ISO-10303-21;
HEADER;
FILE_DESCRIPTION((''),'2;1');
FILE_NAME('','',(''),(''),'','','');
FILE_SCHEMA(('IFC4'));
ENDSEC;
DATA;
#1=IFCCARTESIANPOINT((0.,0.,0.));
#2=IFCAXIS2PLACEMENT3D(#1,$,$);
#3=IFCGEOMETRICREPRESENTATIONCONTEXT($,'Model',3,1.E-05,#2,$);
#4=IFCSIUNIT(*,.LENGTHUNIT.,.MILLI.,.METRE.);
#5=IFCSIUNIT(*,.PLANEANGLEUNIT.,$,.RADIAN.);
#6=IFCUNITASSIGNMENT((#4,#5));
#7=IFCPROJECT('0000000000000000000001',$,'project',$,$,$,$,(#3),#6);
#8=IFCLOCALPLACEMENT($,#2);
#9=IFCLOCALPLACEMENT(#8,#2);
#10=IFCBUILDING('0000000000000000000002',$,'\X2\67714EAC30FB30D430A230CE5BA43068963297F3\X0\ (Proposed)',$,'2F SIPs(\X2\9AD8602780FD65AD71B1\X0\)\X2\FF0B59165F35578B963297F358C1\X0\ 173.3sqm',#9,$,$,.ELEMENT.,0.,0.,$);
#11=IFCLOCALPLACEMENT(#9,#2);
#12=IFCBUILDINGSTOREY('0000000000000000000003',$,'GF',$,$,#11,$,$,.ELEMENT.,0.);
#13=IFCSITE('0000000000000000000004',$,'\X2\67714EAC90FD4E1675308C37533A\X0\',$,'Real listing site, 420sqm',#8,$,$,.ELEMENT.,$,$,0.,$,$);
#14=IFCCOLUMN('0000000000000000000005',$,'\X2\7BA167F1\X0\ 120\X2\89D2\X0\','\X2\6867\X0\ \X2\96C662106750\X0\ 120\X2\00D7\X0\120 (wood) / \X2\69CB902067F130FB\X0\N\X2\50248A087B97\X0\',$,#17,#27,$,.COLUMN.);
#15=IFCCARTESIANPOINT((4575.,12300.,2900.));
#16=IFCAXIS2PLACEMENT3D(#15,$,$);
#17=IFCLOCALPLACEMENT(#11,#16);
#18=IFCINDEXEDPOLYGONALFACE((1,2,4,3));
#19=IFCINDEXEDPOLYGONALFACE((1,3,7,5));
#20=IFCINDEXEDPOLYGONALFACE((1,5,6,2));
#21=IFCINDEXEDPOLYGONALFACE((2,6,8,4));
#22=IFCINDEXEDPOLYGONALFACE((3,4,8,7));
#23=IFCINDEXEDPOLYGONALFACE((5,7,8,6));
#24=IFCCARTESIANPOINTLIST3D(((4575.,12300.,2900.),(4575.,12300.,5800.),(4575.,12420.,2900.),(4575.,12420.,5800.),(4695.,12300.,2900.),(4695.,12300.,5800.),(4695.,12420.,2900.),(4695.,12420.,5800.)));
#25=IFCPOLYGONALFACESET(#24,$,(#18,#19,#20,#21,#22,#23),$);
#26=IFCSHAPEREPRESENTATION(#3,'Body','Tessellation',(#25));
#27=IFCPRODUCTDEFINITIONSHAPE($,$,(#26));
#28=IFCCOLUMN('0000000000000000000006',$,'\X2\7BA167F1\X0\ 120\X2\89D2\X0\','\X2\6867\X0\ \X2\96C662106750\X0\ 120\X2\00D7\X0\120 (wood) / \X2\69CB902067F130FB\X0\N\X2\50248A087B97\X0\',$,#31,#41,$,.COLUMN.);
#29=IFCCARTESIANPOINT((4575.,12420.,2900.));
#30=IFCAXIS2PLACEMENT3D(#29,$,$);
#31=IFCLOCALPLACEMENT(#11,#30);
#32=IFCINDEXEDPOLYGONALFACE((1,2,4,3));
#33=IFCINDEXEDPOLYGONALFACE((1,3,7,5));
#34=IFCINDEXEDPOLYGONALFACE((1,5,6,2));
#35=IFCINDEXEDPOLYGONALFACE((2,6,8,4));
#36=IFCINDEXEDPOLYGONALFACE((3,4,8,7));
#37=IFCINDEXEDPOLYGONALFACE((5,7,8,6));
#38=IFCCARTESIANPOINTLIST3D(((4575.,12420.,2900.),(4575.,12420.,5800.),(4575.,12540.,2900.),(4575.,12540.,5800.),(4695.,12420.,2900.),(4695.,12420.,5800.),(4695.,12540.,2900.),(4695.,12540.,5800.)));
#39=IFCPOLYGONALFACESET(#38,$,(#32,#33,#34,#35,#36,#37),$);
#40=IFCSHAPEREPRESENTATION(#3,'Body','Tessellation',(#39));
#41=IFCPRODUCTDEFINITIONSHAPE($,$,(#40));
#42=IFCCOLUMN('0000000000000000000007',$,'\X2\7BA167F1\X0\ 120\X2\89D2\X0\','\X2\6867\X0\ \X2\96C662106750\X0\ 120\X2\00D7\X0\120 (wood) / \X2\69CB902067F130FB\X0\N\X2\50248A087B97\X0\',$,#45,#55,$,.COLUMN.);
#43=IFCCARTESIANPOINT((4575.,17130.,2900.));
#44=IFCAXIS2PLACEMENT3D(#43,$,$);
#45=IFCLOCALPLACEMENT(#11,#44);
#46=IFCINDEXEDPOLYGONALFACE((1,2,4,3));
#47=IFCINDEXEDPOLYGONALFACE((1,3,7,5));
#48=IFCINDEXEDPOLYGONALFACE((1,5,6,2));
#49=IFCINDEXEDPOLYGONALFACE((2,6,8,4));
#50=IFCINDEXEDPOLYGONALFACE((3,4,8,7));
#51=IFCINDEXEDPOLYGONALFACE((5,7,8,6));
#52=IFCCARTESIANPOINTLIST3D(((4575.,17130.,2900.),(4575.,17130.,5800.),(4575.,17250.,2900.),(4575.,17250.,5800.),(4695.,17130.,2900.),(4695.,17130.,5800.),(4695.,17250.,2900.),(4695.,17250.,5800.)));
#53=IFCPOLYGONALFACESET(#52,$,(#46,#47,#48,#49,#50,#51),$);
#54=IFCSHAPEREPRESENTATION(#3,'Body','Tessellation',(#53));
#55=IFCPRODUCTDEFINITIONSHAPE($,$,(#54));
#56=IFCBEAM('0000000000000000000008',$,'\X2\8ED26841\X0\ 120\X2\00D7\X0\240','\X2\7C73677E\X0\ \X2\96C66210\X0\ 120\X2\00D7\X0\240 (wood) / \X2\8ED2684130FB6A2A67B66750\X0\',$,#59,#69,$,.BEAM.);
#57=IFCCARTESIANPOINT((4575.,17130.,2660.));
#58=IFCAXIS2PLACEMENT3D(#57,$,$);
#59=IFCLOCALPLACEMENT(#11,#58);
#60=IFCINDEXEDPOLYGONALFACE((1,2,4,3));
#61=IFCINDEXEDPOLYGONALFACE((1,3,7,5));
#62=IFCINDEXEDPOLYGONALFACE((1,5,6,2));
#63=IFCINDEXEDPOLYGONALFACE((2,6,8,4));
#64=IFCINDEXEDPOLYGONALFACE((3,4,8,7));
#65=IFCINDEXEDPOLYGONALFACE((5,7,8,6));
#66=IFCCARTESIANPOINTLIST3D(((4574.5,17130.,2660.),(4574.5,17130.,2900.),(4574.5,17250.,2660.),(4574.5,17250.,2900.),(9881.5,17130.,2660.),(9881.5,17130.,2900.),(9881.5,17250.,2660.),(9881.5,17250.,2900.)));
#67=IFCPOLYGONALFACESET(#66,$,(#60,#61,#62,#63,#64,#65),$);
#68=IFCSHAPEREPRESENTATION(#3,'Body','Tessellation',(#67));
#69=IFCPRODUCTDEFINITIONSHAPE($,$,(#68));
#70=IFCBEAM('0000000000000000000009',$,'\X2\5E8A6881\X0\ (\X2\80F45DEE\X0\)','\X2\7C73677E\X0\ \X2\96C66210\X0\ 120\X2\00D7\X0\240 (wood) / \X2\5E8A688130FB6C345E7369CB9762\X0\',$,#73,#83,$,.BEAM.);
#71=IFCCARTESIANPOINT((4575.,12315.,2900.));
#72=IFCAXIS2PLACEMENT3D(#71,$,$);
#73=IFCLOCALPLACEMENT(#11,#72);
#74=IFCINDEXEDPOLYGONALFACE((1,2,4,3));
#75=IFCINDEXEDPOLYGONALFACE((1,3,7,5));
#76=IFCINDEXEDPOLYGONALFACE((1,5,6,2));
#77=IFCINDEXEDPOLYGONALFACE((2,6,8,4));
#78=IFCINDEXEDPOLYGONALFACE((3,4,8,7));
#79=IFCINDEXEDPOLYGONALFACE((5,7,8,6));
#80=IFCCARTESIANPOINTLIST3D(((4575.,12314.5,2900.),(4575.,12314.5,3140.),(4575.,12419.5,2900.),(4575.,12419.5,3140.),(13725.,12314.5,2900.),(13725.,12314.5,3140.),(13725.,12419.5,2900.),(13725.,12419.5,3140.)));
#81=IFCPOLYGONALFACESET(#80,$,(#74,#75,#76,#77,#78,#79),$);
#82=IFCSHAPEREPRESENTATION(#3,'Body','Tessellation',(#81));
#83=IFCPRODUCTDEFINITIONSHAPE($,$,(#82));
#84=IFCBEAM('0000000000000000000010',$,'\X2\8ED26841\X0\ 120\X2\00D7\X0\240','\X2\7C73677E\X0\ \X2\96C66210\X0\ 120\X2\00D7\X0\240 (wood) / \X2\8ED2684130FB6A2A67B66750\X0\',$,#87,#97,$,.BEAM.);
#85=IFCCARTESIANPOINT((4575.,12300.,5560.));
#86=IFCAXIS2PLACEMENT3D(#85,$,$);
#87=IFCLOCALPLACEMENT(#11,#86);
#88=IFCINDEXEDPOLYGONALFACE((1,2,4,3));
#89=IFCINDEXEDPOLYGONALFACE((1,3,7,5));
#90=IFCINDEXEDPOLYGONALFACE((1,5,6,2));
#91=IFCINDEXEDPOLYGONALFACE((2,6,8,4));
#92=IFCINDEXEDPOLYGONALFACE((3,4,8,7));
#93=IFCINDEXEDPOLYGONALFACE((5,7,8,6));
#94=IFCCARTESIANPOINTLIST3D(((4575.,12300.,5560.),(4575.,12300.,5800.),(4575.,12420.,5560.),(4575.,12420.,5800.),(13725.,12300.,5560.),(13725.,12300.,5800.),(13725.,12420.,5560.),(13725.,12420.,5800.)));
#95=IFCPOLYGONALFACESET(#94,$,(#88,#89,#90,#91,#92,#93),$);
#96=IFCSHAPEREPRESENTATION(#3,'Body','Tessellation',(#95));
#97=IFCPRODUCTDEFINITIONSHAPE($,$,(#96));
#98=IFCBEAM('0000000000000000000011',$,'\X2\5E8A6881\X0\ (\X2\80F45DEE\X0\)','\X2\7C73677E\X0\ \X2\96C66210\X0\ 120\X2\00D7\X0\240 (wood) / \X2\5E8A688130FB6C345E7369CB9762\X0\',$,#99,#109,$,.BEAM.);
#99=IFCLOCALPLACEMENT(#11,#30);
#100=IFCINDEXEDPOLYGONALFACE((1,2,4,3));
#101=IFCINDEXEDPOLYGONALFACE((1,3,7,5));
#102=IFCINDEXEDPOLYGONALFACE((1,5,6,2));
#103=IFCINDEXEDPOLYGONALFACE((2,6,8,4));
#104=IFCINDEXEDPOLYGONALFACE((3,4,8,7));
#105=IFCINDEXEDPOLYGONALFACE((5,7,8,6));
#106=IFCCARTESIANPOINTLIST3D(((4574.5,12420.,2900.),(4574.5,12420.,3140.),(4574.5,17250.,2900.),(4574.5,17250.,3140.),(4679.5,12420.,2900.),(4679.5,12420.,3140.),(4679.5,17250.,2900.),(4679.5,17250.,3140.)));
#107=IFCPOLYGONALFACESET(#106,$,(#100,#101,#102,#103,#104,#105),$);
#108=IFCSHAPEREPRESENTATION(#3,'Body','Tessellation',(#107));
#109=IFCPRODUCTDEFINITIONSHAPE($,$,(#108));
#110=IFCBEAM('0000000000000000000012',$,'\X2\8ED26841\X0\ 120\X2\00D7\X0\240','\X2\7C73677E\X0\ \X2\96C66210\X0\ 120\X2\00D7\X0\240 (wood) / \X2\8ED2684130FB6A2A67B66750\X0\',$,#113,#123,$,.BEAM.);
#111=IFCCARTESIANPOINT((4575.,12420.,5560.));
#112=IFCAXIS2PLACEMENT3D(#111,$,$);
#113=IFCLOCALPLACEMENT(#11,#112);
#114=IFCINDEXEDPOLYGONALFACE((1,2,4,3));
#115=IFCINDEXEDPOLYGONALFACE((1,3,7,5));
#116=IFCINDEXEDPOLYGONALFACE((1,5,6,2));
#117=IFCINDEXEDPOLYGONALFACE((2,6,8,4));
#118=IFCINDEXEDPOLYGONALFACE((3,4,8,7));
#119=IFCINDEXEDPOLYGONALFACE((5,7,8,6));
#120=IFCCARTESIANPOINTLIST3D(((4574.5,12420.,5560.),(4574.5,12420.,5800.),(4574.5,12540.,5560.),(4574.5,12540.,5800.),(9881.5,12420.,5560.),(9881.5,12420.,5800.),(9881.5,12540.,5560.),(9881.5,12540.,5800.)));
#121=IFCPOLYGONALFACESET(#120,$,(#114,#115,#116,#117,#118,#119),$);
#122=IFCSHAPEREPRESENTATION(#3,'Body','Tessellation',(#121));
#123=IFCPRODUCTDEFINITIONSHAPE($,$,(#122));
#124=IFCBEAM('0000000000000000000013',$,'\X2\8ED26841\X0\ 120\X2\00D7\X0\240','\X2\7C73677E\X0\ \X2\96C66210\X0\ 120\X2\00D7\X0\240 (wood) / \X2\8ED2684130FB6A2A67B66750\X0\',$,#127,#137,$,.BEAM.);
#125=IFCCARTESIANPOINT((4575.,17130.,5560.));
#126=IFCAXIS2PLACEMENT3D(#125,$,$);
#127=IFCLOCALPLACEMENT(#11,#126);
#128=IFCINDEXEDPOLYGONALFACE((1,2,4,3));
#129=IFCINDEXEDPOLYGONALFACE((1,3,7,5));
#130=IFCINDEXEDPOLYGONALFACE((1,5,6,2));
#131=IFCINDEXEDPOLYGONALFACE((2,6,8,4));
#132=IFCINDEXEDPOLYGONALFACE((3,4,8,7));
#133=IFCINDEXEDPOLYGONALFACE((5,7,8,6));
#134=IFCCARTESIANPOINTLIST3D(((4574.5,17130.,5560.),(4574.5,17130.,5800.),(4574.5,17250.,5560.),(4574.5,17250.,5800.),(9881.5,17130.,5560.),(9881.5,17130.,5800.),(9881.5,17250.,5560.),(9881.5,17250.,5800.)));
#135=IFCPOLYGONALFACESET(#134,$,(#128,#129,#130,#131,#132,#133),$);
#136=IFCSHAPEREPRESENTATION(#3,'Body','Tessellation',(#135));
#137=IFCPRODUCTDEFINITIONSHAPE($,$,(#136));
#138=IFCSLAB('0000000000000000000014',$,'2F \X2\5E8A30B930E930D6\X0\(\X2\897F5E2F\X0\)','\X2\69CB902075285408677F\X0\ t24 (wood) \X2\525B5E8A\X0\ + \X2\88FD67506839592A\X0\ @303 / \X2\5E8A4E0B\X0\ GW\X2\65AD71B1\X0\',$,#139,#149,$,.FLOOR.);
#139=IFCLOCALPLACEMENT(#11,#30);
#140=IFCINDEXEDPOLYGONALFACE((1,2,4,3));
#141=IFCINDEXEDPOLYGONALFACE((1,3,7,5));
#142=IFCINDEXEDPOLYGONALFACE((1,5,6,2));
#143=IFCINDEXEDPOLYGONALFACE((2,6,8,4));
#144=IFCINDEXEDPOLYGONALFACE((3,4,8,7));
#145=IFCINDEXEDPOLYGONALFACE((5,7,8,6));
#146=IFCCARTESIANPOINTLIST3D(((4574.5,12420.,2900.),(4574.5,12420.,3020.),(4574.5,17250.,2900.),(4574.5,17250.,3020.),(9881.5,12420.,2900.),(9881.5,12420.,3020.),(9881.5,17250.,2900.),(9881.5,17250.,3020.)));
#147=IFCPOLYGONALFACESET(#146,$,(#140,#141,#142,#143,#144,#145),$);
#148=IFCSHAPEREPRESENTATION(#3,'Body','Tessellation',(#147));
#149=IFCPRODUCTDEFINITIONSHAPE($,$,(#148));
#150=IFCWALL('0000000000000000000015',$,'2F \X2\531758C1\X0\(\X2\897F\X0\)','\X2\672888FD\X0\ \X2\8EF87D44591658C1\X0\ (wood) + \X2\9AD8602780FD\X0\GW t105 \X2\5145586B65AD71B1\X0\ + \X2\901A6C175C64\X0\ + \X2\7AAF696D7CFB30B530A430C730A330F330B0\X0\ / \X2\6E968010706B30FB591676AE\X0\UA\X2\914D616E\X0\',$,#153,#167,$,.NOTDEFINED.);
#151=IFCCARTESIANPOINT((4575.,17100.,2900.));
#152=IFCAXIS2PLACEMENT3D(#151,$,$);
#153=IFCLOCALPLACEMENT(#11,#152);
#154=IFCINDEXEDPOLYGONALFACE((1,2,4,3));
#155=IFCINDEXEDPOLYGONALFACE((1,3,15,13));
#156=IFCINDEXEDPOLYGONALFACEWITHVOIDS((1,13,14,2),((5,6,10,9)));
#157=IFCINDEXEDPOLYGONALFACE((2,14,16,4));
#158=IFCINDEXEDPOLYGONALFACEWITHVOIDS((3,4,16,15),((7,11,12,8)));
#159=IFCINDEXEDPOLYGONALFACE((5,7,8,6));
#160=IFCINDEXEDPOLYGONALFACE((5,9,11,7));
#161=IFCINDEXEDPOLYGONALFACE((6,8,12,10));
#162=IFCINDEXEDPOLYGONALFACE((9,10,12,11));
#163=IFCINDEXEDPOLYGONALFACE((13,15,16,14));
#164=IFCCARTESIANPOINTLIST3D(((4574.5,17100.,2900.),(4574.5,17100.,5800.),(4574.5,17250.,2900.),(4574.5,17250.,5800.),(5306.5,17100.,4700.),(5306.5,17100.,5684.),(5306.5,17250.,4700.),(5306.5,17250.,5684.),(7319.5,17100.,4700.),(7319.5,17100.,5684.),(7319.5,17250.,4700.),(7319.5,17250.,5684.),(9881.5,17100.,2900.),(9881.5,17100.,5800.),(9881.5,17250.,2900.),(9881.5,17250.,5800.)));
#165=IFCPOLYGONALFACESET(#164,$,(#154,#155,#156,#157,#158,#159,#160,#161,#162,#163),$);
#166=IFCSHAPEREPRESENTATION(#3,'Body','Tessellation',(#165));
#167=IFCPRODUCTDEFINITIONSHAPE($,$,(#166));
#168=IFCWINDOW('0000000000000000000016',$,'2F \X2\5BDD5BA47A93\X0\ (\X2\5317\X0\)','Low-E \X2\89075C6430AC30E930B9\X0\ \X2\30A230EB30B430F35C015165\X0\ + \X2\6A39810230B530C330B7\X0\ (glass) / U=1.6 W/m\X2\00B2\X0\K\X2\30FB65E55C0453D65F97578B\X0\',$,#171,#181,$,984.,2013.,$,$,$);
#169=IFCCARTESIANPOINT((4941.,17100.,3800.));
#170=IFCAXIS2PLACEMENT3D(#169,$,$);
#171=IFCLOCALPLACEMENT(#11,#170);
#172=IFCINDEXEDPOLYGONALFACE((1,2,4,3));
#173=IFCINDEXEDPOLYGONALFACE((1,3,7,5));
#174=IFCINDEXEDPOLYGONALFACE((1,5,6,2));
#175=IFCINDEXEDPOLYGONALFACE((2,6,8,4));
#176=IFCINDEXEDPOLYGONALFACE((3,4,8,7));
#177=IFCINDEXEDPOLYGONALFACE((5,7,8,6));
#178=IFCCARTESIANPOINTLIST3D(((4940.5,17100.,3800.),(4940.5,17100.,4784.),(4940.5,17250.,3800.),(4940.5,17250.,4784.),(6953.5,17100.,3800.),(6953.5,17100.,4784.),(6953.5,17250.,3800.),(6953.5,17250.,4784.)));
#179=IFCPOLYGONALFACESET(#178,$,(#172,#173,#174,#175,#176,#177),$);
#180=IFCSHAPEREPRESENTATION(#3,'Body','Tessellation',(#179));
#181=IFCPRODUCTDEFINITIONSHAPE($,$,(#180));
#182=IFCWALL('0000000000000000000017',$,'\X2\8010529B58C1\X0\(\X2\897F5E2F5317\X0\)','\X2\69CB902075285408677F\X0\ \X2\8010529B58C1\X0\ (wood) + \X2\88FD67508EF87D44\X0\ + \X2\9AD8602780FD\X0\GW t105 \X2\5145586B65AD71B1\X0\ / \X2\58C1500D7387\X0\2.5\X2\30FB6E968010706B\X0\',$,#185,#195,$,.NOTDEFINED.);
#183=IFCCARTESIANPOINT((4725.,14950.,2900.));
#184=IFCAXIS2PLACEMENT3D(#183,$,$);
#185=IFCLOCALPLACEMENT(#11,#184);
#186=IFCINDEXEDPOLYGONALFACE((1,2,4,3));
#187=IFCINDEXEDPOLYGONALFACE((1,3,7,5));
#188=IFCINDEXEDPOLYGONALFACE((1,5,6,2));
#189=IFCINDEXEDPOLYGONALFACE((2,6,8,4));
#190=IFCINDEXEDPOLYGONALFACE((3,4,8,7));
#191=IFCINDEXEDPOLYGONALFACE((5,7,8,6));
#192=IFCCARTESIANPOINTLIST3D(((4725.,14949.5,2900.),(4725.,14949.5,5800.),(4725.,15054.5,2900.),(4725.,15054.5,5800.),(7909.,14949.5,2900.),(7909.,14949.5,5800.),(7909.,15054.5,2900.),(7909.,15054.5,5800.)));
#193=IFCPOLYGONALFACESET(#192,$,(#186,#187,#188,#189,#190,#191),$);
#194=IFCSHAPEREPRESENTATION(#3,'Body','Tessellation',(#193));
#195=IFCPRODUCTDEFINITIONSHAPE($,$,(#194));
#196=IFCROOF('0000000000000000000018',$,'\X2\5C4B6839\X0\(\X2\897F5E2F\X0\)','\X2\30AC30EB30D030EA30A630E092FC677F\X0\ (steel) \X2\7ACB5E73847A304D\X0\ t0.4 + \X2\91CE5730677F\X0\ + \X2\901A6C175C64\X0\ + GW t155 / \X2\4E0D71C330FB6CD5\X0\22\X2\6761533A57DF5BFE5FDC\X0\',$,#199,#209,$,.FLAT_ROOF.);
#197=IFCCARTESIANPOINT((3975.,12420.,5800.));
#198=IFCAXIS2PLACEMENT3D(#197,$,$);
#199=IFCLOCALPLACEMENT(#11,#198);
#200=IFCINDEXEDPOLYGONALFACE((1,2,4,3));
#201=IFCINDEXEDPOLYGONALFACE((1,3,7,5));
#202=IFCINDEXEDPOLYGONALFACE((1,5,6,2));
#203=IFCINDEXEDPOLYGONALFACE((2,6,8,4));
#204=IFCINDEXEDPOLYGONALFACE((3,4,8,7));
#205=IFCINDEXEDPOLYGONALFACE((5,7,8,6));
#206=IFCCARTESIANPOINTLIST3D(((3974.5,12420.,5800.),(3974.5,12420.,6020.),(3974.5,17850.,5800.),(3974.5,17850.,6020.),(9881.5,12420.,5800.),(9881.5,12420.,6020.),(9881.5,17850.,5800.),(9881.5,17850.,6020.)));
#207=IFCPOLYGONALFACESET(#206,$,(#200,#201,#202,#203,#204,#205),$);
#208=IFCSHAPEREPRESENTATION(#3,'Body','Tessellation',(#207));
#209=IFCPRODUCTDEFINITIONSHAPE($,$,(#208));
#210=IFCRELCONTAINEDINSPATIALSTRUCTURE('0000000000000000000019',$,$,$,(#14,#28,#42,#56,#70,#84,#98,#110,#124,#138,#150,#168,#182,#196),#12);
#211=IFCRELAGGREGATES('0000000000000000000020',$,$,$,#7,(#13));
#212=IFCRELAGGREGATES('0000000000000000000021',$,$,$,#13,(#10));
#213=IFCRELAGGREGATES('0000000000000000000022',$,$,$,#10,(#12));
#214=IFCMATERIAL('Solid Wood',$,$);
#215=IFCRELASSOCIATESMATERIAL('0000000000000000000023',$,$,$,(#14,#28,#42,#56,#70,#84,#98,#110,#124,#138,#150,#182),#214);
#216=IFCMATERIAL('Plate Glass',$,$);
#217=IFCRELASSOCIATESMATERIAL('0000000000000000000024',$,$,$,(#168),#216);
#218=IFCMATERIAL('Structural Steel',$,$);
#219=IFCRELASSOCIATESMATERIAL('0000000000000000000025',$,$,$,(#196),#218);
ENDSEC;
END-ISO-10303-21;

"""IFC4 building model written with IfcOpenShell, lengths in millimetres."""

from ifc_helpers import new_model, si_unit, frame, frame_2d, origin, place, context, project, spatial, rectangle, extrude, material, element, fill, save


model = new_model("IFC4")

# Units and contexts
model_context = context("Model", 3, precision=1e-05, world=origin())
ifc_project = project(units=[si_unit("LENGTHUNIT", "METRE", prefix="MILLI"), si_unit("PLANEANGLEUNIT", "RADIAN")], contexts=[model_context])

# Site, building, storey
site_placement = place(None, origin())
site = spatial("IfcSite", under=ifc_project, at=site_placement, Name="東京都世田谷区", ObjectType="Real listing site, 420sqm", CompositionType="ELEMENT", RefElevation=0.0)
building_placement = place(site_placement, origin())
building = spatial("IfcBuilding", under=site, at=building_placement, Name="東京・ピアノ室と防音 (Proposed)", ObjectType="2F SIPs(高性能断熱)＋外張型防音壁 173.3sqm", CompositionType="ELEMENT", ElevationOfRefHeight=0.0, ElevationOfTerrain=0.0)
storey_placement = place(building_placement, origin())
storey = spatial("IfcBuildingStorey", under=building, at=storey_placement, Name="GF", CompositionType="ELEMENT", Elevation=0.0)

# Columns
ifc_material_1 = material(Name="Solid Wood")
column_1_placement = place(storey_placement, frame((4575.0, 12300.0, 2900.0)))
element("IfcColumn", 1, at=column_1_placement, inside=storey, material=ifc_material_1, Name="管柱 120角", Description="桧 集成材 120×120 (wood) / 構造柱・N値計算", PredefinedType="COLUMN", context=model_context, shape_type="SweptSolid", body=[
    extrude(rectangle(XDim=120.0, YDim=120.0, at=frame_2d((60.0, 60.0))), frame((4575.0, 12300.0, 2900.0)), (0.0, 0.0, 1.0), 2900.0),
])
column_2_placement = place(storey_placement, frame((4575.0, 12420.0, 2900.0)))
element("IfcColumn", 2, at=column_2_placement, inside=storey, material=ifc_material_1, Name="管柱 120角", Description="桧 集成材 120×120 (wood) / 構造柱・N値計算", PredefinedType="COLUMN", context=model_context, shape_type="SweptSolid", body=[
    extrude(rectangle(XDim=120.0, YDim=120.0, at=frame_2d((60.0, 60.0))), frame((4575.0, 12420.0, 2900.0)), (0.0, 0.0, 1.0), 2900.0),
])
column_3_placement = place(storey_placement, frame((4575.0, 17130.0, 2900.0)))
element("IfcColumn", 3, at=column_3_placement, inside=storey, material=ifc_material_1, Name="管柱 120角", Description="桧 集成材 120×120 (wood) / 構造柱・N値計算", PredefinedType="COLUMN", context=model_context, shape_type="SweptSolid", body=[
    extrude(rectangle(XDim=120.0, YDim=120.0, at=frame_2d((60.0, 60.0))), frame((4575.0, 17130.0, 2900.0)), (0.0, 0.0, 1.0), 2900.0),
])

# Beams
beam_1_placement = place(storey_placement, frame((4575.0, 17130.0, 2660.0)))
element("IfcBeam", 4, at=beam_1_placement, inside=storey, material=ifc_material_1, Name="軒桁 120×240", Description="米松 集成 120×240 (wood) / 軒桁・横架材", PredefinedType="BEAM", context=model_context, shape_type="SweptSolid", body=[
    extrude(rectangle(XDim=5307.0, YDim=120.0, at=frame_2d((2653.0, 60.0))), frame((4575.0, 17130.0, 2660.0)), (0.0, 0.0, 1.0), 240.0),
])
beam_2_placement = place(storey_placement, frame((4575.0, 12315.0, 2900.0)))
element("IfcBeam", 5, at=beam_2_placement, inside=storey, material=ifc_material_1, Name="床梁 (胴差)", Description="米松 集成 120×240 (wood) / 床梁・水平構面", PredefinedType="BEAM", context=model_context, shape_type="SweptSolid", body=[
    extrude(rectangle(XDim=9150.0, YDim=105.0, at=frame_2d((4575.0, 52.0))), frame((4575.0, 12315.0, 2900.0)), (0.0, 0.0, 1.0), 240.0),
])
beam_3_placement = place(storey_placement, frame((4575.0, 12300.0, 5560.0)))
element("IfcBeam", 6, at=beam_3_placement, inside=storey, material=ifc_material_1, Name="軒桁 120×240", Description="米松 集成 120×240 (wood) / 軒桁・横架材", PredefinedType="BEAM", context=model_context, shape_type="SweptSolid", body=[
    extrude(rectangle(XDim=9150.0, YDim=120.0, at=frame_2d((4575.0, 60.0))), frame((4575.0, 12300.0, 5560.0)), (0.0, 0.0, 1.0), 240.0),
])
beam_4_placement = place(storey_placement, frame((4575.0, 12420.0, 2900.0)))
element("IfcBeam", 7, at=beam_4_placement, inside=storey, material=ifc_material_1, Name="床梁 (胴差)", Description="米松 集成 120×240 (wood) / 床梁・水平構面", PredefinedType="BEAM", context=model_context, shape_type="SweptSolid", body=[
    extrude(rectangle(XDim=105.0, YDim=4830.0, at=frame_2d((52.0, 2415.0))), frame((4575.0, 12420.0, 2900.0)), (0.0, 0.0, 1.0), 240.0),
])
beam_5_placement = place(storey_placement, frame((4575.0, 12420.0, 5560.0)))
element("IfcBeam", 8, at=beam_5_placement, inside=storey, material=ifc_material_1, Name="軒桁 120×240", Description="米松 集成 120×240 (wood) / 軒桁・横架材", PredefinedType="BEAM", context=model_context, shape_type="SweptSolid", body=[
    extrude(rectangle(XDim=5307.0, YDim=120.0, at=frame_2d((2653.0, 60.0))), frame((4575.0, 12420.0, 5560.0)), (0.0, 0.0, 1.0), 240.0),
])
beam_6_placement = place(storey_placement, frame((4575.0, 17130.0, 5560.0)))
element("IfcBeam", 9, at=beam_6_placement, inside=storey, material=ifc_material_1, Name="軒桁 120×240", Description="米松 集成 120×240 (wood) / 軒桁・横架材", PredefinedType="BEAM", context=model_context, shape_type="SweptSolid", body=[
    extrude(rectangle(XDim=5307.0, YDim=120.0, at=frame_2d((2653.0, 60.0))), frame((4575.0, 17130.0, 5560.0)), (0.0, 0.0, 1.0), 240.0),
])

# Slab
slab_placement = place(storey_placement, frame((4575.0, 12420.0, 2900.0)))
element("IfcSlab", 10, at=slab_placement, inside=storey, material=ifc_material_1, Name="2F 床スラブ(西帯)", Description="構造用合板 t24 (wood) 剛床 + 製材根太 @303 / 床下 GW断熱", PredefinedType="FLOOR", context=model_context, shape_type="SweptSolid", body=[
    extrude(rectangle(XDim=5307.0, YDim=4830.0, at=frame_2d((2653.0, 2415.0))), frame((4575.0, 12420.0, 2900.0)), (0.0, 0.0, 1.0), 120.0),
])

# Wall, opening, window
wall_1_placement = place(storey_placement, frame((4575.0, 17100.0, 2900.0)))
wall_1 = element("IfcWall", 11, at=wall_1_placement, inside=storey, material=ifc_material_1, Name="2F 北壁(西)", Description="木製 軸組外壁 (wood) + 高性能GW t105 充填断熱 + 通気層 + 窯業系サイディング / 準耐火・外皮UA配慮", PredefinedType="NOTDEFINED", context=model_context, shape_type="SweptSolid", body=[
    extrude(rectangle(XDim=5307.0, YDim=150.0, at=frame_2d((2653.0, 75.0))), frame((4575.0, 17100.0, 2900.0)), (0.0, 0.0, 1.0), 2900.0),
])
opening_placement = place(storey_placement, frame((4941.0, 17100.0, 3800.0)))
opening = element("IfcOpeningElement", 12, at=opening_placement, cuts=wall_1, PredefinedType="NOTDEFINED", context=model_context, shape_type="SweptSolid", body=[
    extrude(rectangle(XDim=2013.0, YDim=150.0, at=frame_2d((1006.0, 75.0))), frame((4941.0, 17100.0, 3800.0)), (0.0, 0.0, 1.0), 984.0),
])
ifc_material_2 = material(Name="Plate Glass")
window_placement = place(storey_placement, frame((4941.0, 17100.0, 3800.0)))
window = element("IfcWindow", 13, at=window_placement, inside=storey, material=ifc_material_2, Name="2F 寝室窓 (北)", Description="Low-E 複層ガラス アルゴン封入 + 樹脂サッシ (glass) / U=1.6 W/m²K・日射取得型", OverallHeight=984.0, OverallWidth=2013.0, context=model_context, shape_type="SweptSolid", body=[
    extrude(rectangle(XDim=2013.0, YDim=150.0, at=frame_2d((1006.0, 75.0))), frame((4941.0, 17100.0, 3800.0)), (0.0, 0.0, 1.0), 984.0),
])
fill(opening, window)

# Wall
wall_2_placement = place(storey_placement, frame((4725.0, 14950.0, 2900.0)))
element("IfcWall", 14, at=wall_2_placement, inside=storey, material=ifc_material_1, Name="耐力壁(西帯北)", Description="構造用合板 耐力壁 (wood) + 製材軸組 + 高性能GW t105 充填断熱 / 壁倍率2.5・準耐火", PredefinedType="NOTDEFINED", context=model_context, shape_type="SweptSolid", body=[
    extrude(rectangle(XDim=3184.0, YDim=105.0, at=frame_2d((1592.0, 52.0))), frame((4725.0, 14950.0, 2900.0)), (0.0, 0.0, 1.0), 2900.0),
])

# Roof
ifc_material_3 = material(Name="Structural Steel")
for number, where, name in (
    (15, (3975.0, 12420.0, 5800.0), "屋根(西帯)"),
):
    element("IfcRoof", number, at=place(storey_placement, frame(where)), inside=storey, material=ifc_material_3, Name=name, Description="ガルバリウム鋼板 (steel) 立平葺き t0.4 + 野地板 + 通気層 + GW t155 / 不燃・法22条区域対応", PredefinedType="FLAT_ROOF", context=model_context, shape_type="SweptSolid", body=[
        extrude(rectangle(XDim=5907.0, YDim=5430.0, at=frame_2d((2953.0, 2715.0))), frame((3975.0, 12420.0, 5800.0)), (0.0, 0.0, 1.0), 220.0),
    ])

save(model, "model.ifc")
